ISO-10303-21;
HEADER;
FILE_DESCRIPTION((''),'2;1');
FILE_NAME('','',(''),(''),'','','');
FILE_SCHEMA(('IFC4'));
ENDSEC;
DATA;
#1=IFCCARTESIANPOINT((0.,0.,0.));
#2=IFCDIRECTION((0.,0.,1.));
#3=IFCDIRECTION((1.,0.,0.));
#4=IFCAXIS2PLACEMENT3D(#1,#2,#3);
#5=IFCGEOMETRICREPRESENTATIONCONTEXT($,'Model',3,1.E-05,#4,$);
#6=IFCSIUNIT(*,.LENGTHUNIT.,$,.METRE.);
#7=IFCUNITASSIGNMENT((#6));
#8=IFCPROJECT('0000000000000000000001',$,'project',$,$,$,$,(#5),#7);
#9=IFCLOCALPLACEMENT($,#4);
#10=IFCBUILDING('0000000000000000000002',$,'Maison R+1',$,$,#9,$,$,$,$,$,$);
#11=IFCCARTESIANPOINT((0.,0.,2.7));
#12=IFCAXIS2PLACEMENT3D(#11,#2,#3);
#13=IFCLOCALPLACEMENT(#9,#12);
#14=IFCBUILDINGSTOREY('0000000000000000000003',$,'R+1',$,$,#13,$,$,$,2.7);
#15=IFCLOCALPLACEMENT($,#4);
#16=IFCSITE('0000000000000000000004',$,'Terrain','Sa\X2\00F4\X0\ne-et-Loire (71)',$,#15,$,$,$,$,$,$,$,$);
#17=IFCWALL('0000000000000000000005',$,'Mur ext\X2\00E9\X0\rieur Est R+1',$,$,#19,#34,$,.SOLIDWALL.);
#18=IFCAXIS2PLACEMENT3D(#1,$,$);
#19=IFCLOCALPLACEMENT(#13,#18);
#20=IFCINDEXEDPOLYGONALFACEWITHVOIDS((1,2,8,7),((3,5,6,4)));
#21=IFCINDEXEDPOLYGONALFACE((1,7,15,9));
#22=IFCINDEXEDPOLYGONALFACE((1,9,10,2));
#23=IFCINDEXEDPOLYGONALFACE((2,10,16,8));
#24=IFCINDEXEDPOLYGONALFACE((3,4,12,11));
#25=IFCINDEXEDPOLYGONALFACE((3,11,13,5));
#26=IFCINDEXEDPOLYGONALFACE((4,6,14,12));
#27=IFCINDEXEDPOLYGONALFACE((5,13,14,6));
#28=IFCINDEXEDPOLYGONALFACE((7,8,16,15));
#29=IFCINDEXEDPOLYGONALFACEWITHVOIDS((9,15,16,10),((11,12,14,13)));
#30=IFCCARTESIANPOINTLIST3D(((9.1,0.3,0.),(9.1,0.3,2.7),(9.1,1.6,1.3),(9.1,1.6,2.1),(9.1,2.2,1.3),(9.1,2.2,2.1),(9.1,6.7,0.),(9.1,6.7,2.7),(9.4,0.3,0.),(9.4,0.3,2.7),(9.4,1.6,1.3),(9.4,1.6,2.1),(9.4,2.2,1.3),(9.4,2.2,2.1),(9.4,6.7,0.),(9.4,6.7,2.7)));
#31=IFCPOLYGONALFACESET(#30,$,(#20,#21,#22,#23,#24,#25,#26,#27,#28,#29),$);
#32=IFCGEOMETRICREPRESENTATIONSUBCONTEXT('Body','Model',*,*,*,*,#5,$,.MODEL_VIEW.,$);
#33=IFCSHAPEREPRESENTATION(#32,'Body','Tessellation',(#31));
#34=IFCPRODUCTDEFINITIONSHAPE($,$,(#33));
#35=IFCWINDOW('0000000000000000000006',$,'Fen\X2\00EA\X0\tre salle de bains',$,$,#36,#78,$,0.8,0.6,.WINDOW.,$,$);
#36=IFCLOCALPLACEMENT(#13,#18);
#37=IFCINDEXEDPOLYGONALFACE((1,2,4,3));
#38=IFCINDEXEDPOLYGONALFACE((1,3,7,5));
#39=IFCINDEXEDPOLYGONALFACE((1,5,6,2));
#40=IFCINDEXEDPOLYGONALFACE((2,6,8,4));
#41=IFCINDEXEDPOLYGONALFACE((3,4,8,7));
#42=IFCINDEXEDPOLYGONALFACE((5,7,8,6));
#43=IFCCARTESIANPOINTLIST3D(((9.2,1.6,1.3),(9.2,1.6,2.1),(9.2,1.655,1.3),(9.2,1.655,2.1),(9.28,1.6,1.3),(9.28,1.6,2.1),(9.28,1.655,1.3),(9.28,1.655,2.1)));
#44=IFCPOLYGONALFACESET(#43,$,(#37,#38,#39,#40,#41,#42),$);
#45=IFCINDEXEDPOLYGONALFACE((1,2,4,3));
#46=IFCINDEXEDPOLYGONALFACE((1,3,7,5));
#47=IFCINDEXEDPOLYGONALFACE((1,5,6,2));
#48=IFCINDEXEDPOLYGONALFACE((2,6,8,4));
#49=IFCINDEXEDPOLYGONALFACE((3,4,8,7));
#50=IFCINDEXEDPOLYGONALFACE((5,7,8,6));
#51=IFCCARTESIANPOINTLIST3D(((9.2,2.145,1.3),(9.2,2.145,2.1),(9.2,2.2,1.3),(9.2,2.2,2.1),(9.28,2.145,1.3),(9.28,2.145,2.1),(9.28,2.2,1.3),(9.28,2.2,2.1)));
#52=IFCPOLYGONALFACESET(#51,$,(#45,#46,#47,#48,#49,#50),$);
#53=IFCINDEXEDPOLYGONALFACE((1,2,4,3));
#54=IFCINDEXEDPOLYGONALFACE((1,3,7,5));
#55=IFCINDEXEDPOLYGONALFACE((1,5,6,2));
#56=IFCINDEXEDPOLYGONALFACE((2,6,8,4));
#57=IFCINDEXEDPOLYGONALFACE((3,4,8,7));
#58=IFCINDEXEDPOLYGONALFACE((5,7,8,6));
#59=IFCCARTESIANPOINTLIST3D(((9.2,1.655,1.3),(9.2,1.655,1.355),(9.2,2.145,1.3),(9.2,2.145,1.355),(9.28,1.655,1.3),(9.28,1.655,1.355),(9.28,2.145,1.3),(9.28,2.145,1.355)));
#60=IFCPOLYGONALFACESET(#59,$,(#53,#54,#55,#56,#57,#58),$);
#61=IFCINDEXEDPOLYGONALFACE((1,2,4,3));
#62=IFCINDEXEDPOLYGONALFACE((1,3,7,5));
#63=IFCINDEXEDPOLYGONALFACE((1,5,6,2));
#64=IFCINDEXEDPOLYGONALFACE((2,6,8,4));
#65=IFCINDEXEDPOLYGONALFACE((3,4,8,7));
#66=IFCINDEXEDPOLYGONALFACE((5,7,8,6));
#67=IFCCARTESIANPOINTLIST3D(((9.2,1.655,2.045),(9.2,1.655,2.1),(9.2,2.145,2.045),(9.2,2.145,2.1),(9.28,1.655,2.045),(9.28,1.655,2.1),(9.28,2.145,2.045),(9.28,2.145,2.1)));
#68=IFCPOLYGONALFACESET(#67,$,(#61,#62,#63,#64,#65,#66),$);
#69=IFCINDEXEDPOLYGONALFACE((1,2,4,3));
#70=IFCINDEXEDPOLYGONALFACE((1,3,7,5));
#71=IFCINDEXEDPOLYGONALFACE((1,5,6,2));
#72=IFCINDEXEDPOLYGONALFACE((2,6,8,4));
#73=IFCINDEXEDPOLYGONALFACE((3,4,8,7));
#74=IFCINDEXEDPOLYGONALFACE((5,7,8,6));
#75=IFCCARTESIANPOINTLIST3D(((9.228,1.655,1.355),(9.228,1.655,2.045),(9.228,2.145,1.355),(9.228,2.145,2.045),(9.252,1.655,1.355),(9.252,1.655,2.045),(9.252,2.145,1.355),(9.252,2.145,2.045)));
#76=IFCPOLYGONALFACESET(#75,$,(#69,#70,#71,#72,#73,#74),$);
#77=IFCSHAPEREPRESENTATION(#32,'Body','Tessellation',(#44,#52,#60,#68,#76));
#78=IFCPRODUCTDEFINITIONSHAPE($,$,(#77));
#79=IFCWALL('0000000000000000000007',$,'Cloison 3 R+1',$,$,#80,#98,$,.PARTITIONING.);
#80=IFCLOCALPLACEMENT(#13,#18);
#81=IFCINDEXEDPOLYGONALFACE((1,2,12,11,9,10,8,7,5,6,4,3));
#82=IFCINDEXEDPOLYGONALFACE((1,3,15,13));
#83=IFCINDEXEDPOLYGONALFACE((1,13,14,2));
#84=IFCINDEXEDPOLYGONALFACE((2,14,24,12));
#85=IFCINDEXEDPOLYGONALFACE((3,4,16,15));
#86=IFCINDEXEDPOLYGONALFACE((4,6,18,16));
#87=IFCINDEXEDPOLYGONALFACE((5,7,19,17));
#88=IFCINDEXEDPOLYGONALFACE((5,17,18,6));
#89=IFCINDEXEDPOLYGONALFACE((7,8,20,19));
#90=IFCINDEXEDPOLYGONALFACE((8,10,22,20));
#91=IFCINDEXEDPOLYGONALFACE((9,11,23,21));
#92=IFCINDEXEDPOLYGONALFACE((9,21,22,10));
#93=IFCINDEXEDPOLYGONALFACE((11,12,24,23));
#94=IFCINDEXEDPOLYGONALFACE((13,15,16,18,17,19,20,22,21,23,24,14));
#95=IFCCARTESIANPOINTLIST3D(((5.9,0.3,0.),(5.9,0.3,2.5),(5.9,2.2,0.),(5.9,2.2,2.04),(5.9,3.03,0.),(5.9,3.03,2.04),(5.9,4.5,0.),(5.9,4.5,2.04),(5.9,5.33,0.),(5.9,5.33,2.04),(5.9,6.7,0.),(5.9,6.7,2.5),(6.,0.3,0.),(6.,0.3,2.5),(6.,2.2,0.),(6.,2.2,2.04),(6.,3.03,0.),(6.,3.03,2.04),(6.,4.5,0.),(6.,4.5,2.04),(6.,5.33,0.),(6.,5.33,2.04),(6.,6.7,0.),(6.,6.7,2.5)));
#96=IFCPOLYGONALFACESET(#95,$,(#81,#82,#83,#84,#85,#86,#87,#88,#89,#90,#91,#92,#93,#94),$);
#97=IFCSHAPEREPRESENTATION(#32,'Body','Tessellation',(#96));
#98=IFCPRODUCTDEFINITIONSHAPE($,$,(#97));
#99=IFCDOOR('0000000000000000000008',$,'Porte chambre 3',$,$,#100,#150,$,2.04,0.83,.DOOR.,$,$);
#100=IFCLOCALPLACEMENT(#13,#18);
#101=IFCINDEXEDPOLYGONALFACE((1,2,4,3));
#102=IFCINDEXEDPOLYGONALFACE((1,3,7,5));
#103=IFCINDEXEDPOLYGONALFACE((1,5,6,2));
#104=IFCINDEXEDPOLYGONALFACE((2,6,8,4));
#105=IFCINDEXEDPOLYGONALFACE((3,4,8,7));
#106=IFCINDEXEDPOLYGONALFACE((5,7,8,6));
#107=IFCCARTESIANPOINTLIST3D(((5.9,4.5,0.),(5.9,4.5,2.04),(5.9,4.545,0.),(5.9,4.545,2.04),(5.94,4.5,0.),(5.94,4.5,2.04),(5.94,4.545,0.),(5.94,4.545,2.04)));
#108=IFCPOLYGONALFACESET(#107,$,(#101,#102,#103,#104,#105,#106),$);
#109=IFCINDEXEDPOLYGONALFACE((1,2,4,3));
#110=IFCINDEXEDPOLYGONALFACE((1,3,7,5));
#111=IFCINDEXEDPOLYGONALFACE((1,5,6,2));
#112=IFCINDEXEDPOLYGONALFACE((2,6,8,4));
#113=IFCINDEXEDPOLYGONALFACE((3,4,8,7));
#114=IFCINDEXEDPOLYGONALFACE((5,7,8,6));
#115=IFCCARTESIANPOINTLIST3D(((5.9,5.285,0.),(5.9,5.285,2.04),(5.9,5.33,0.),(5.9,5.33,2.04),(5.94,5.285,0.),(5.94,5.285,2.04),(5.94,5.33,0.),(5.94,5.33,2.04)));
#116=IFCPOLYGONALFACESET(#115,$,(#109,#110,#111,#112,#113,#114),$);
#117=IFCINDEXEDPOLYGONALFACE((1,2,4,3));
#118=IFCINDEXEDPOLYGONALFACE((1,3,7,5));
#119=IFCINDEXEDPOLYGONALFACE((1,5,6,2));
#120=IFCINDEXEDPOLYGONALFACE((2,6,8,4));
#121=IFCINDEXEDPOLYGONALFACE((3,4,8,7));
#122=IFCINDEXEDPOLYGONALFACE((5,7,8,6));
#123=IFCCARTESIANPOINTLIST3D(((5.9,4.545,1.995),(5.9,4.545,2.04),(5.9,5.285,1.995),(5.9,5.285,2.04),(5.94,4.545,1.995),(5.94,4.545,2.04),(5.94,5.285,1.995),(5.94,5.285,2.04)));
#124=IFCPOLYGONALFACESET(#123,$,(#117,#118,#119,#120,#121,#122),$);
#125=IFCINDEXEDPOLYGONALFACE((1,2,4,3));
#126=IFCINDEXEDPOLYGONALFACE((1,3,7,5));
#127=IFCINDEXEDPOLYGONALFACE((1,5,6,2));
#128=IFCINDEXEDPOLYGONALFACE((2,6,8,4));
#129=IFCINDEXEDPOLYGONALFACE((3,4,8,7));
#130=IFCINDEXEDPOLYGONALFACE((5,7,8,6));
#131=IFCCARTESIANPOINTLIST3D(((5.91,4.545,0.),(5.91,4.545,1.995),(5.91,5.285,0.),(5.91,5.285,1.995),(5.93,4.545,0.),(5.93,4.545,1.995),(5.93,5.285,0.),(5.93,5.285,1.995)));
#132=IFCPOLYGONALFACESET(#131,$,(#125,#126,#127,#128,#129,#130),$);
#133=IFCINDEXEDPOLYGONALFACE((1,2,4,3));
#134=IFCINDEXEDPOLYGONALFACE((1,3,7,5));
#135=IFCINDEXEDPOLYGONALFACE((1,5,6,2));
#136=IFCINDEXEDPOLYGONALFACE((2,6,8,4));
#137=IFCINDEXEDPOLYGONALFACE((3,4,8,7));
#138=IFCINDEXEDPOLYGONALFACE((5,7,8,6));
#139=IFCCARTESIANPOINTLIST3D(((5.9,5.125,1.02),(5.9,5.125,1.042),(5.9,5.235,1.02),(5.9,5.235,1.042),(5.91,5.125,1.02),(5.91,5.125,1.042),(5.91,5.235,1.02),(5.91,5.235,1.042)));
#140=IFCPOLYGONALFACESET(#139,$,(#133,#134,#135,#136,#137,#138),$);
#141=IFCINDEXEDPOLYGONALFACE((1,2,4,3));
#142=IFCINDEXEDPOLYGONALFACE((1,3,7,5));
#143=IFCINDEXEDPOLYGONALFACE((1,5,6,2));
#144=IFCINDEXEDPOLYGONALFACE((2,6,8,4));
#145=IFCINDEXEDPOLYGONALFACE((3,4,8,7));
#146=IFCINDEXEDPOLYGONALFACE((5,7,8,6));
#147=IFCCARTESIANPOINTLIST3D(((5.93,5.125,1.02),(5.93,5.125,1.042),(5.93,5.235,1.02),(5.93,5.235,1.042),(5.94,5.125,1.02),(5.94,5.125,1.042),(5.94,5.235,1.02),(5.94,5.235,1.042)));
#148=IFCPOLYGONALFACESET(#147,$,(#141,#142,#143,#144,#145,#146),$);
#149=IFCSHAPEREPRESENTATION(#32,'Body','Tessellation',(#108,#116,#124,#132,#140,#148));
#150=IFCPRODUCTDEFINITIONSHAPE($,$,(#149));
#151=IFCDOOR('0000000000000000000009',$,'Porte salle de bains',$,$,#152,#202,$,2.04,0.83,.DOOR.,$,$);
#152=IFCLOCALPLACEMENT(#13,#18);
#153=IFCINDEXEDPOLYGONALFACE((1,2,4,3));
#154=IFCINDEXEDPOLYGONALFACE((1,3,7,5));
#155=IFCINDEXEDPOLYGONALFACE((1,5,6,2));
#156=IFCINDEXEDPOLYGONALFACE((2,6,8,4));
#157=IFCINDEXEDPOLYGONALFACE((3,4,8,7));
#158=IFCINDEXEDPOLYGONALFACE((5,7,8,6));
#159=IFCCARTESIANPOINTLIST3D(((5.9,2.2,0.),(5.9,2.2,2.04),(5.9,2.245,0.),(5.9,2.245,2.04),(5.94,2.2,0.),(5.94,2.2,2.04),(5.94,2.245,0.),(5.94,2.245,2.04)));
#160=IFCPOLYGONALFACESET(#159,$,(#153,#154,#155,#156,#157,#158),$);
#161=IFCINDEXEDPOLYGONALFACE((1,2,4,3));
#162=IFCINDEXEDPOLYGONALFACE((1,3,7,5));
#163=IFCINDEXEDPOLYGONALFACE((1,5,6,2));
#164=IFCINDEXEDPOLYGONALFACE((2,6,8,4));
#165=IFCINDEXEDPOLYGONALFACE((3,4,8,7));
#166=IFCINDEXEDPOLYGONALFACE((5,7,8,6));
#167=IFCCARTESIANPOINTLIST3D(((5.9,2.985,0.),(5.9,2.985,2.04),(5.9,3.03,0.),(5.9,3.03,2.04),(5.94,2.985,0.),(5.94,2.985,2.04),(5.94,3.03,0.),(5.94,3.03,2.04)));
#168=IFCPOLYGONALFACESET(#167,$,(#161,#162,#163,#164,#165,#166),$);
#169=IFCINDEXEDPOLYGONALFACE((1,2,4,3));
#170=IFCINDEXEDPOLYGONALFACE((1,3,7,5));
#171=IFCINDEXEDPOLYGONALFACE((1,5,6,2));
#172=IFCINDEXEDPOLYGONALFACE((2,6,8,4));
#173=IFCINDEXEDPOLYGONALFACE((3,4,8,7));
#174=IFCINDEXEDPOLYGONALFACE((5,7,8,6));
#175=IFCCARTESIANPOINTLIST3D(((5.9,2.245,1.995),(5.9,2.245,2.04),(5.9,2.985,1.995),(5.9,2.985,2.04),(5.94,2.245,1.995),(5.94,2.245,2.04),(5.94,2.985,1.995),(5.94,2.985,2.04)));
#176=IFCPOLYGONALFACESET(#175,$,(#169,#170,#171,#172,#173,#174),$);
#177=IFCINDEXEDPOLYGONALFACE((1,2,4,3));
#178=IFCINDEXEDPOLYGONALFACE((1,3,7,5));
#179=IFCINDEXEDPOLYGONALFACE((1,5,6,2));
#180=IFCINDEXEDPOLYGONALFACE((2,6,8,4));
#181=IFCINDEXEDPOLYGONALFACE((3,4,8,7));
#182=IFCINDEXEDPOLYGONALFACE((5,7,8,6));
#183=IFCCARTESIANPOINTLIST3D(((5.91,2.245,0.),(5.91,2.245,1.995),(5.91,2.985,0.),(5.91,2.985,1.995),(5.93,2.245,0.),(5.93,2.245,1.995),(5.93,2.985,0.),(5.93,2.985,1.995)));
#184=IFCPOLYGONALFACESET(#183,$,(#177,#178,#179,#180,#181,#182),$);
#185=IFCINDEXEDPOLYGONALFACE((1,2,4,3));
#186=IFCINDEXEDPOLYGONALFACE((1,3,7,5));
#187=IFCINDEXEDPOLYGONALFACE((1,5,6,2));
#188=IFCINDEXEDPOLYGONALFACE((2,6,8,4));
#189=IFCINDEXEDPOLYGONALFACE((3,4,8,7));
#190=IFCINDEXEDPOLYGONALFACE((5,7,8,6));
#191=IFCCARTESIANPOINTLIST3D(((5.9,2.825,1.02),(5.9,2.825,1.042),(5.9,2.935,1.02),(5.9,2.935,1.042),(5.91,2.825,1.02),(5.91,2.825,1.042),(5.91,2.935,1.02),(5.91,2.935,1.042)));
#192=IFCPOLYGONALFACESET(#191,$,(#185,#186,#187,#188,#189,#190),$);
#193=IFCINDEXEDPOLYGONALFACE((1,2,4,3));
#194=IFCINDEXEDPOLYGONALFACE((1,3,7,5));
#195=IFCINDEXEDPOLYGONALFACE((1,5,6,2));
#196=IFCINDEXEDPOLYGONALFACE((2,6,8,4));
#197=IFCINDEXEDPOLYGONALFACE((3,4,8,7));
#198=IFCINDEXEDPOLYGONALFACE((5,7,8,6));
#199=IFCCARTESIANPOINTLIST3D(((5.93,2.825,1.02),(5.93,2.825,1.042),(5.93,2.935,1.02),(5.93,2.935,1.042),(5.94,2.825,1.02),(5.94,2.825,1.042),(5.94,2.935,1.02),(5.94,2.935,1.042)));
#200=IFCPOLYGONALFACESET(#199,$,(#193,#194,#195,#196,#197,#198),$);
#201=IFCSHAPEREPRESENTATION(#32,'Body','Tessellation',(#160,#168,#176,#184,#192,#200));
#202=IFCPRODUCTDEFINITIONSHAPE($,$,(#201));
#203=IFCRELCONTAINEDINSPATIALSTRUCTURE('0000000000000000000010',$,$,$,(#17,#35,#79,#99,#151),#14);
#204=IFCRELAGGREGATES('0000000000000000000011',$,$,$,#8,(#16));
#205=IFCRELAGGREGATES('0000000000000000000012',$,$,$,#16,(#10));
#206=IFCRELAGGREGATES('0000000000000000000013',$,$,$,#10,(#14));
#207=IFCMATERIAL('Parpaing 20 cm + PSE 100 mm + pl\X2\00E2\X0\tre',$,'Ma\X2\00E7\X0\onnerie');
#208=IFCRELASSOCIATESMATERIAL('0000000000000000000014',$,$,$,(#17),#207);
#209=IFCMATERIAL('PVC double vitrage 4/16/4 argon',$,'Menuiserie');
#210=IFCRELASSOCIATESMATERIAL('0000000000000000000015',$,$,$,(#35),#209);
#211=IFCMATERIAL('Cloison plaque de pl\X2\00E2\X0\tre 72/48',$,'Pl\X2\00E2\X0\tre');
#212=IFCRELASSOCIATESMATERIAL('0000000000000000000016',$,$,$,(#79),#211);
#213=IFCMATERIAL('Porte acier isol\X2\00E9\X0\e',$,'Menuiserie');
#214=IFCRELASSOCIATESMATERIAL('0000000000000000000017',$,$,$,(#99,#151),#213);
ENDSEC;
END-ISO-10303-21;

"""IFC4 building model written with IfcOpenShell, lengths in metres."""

from ifc_helpers import new_model, si_unit, frame, frame_2d, origin_with_axes, place, context, subcontext, project, spatial, rectangle, extrude, material, element, fill, save


model = new_model("IFC4")

# Units and contexts
model_context = context("Model", 3, precision=1e-05, world=origin_with_axes())
body_context = subcontext(model_context, "Body", "Model", "MODEL_VIEW")
ifc_project = project(units=[si_unit("LENGTHUNIT", "METRE")], contexts=[model_context])

# Site, building, storey
site_placement = place(None, origin_with_axes())
site = spatial("IfcSite", under=ifc_project, at=site_placement, Name="Terrain", Description="Saône-et-Loire (71)")
building_placement = place(None, origin_with_axes())
building = spatial("IfcBuilding", under=site, at=building_placement, Name="Maison R+1")
storey_placement = place(building_placement, frame((0.0, 0.0, 2.7), z_axis=(0.0, 0.0, 1.0), x_axis=(1.0, 0.0, 0.0)))
storey = spatial("IfcBuildingStorey", under=building, at=storey_placement, Name="R+1", Elevation=2.7)

# Wall, opening, window
ifc_material_1 = material(Name="Parpaing 20 cm + PSE 100 mm + plâtre", Category="Maçonnerie")
wall_1_placement = place(storey_placement, frame((9.1, 0.3, 0.0), z_axis=(0.0, 0.0, 1.0), x_axis=(1.0, 0.0, 0.0)))
wall_1 = element("IfcWall", 1, at=wall_1_placement, inside=storey, material=ifc_material_1, Name="Mur extérieur Est R+1", PredefinedType="SOLIDWALL", context=body_context, shape_type="SweptSolid", body=[
    extrude(rectangle(XDim=0.3, YDim=6.4, at=frame_2d((0.15, 3.2))), origin_with_axes(), (0.0, 0.0, 1.0), 2.7),
])
opening_1_placement = place(storey_placement, frame((9.05, 1.6, 1.3), z_axis=(0.0, 0.0, 1.0), x_axis=(1.0, 0.0, 0.0)))
opening_1 = element("IfcOpeningElement", 2, at=opening_1_placement, cuts=wall_1, context=body_context, shape_type="SweptSolid", body=[
    extrude(rectangle(XDim=0.4, YDim=0.6, at=frame_2d((0.2, 0.3))), origin_with_axes(), (0.0, 0.0, 1.0), 0.8),
])
ifc_material_2 = material(Name="PVC double vitrage 4/16/4 argon", Category="Menuiserie")
window_placement = place(storey_placement, frame((9.2, 1.6, 1.3), z_axis=(0.0, 0.0, 1.0), x_axis=(1.0, 0.0, 0.0)))
window = element("IfcWindow", 3, at=window_placement, inside=storey, material=ifc_material_2, Name="Fenêtre salle de bains", OverallHeight=0.8, OverallWidth=0.6, PredefinedType="WINDOW", context=body_context, shape_type="SweptSolid", body=[
    extrude(rectangle(XDim=0.08, YDim=0.055, at=frame_2d((0.04, 0.0275))), origin_with_axes(), (0.0, 0.0, 1.0), 0.8),
    extrude(rectangle(XDim=0.08, YDim=0.055, at=frame_2d((0.04, 0.0275))), frame((0.0, 0.545, 0.0), z_axis=(0.0, 0.0, 1.0), x_axis=(1.0, 0.0, 0.0)), (0.0, 0.0, 1.0), 0.8),
    extrude(rectangle(XDim=0.08, YDim=0.49, at=frame_2d((0.04, 0.245))), frame((0.0, 0.055, 0.0), z_axis=(0.0, 0.0, 1.0), x_axis=(1.0, 0.0, 0.0)), (0.0, 0.0, 1.0), 0.055),
    extrude(rectangle(XDim=0.08, YDim=0.49, at=frame_2d((0.04, 0.245))), frame((0.0, 0.055, 0.745), z_axis=(0.0, 0.0, 1.0), x_axis=(1.0, 0.0, 0.0)), (0.0, 0.0, 1.0), 0.055),
    extrude(rectangle(XDim=0.024, YDim=0.49, at=frame_2d((0.012, 0.245))), frame((0.028, 0.055, 0.055), z_axis=(0.0, 0.0, 1.0), x_axis=(1.0, 0.0, 0.0)), (0.0, 0.0, 1.0), 0.69),
])
fill(opening_1, window)

# Wall, openings, doors
ifc_material_3 = material(Name="Cloison plaque de plâtre 72/48", Category="Plâtre")
wall_2_placement = place(storey_placement, frame((5.9, 0.3, 0.0), z_axis=(0.0, 0.0, 1.0), x_axis=(1.0, 0.0, 0.0)))
wall_2 = element("IfcWall", 4, at=wall_2_placement, inside=storey, material=ifc_material_3, Name="Cloison 3 R+1", PredefinedType="PARTITIONING", context=body_context, shape_type="SweptSolid", body=[
    extrude(rectangle(XDim=0.1, YDim=6.4, at=frame_2d((0.05, 3.2))), origin_with_axes(), (0.0, 0.0, 1.0), 2.5),
])
opening_2_placement = place(storey_placement, frame((5.85, 4.5, 0.0), z_axis=(0.0, 0.0, 1.0), x_axis=(1.0, 0.0, 0.0)))
opening_2 = element("IfcOpeningElement", 5, at=opening_2_placement, cuts=wall_2, context=body_context, shape_type="SweptSolid", body=[
    extrude(rectangle(XDim=0.2, YDim=0.83, at=frame_2d((0.1, 0.415))), origin_with_axes(), (0.0, 0.0, 1.0), 2.04),
])
opening_3_placement = place(storey_placement, frame((5.85, 2.2, 0.0), z_axis=(0.0, 0.0, 1.0), x_axis=(1.0, 0.0, 0.0)))
opening_3 = element("IfcOpeningElement", 6, at=opening_3_placement, cuts=wall_2, context=body_context, shape_type="SweptSolid", body=[
    extrude(rectangle(XDim=0.2, YDim=0.83, at=frame_2d((0.1, 0.415))), origin_with_axes(), (0.0, 0.0, 1.0), 2.04),
])
ifc_material_4 = material(Name="Porte acier isolée", Category="Menuiserie")
door_1_placement = place(storey_placement, frame((5.9, 4.5, 0.0), z_axis=(0.0, 0.0, 1.0), x_axis=(1.0, 0.0, 0.0)))
door_1 = element("IfcDoor", 7, at=door_1_placement, inside=storey, material=ifc_material_4, Name="Porte chambre 3", OverallHeight=2.04, OverallWidth=0.83, PredefinedType="DOOR", context=body_context, shape_type="SweptSolid", body=[
    extrude(rectangle(XDim=0.04, YDim=0.045, at=frame_2d((0.02, 0.0225))), origin_with_axes(), (0.0, 0.0, 1.0), 2.04),
    extrude(rectangle(XDim=0.04, YDim=0.045, at=frame_2d((0.02, 0.0225))), frame((0.0, 0.785, 0.0), z_axis=(0.0, 0.0, 1.0), x_axis=(1.0, 0.0, 0.0)), (0.0, 0.0, 1.0), 2.04),
    extrude(rectangle(XDim=0.04, YDim=0.74, at=frame_2d((0.02, 0.37))), frame((0.0, 0.045, 1.995), z_axis=(0.0, 0.0, 1.0), x_axis=(1.0, 0.0, 0.0)), (0.0, 0.0, 1.0), 0.045),
    extrude(rectangle(XDim=0.02, YDim=0.74, at=frame_2d((0.01, 0.37))), frame((0.01, 0.045, 0.0), z_axis=(0.0, 0.0, 1.0), x_axis=(1.0, 0.0, 0.0)), (0.0, 0.0, 1.0), 1.995),
    extrude(rectangle(XDim=0.01, YDim=0.11, at=frame_2d((0.005, 0.055))), frame((0.0, 0.625, 1.02), z_axis=(0.0, 0.0, 1.0), x_axis=(1.0, 0.0, 0.0)), (0.0, 0.0, 1.0), 0.022),
    extrude(rectangle(XDim=0.01, YDim=0.11, at=frame_2d((0.005, 0.055))), frame((0.03, 0.625, 1.02), z_axis=(0.0, 0.0, 1.0), x_axis=(1.0, 0.0, 0.0)), (0.0, 0.0, 1.0), 0.022),
])
fill(opening_2, door_1)
door_2_placement = place(storey_placement, frame((5.9, 2.2, 0.0), z_axis=(0.0, 0.0, 1.0), x_axis=(1.0, 0.0, 0.0)))
door_2 = element("IfcDoor", 8, at=door_2_placement, inside=storey, material=ifc_material_4, Name="Porte salle de bains", OverallHeight=2.04, OverallWidth=0.83, PredefinedType="DOOR", context=body_context, shape_type="SweptSolid", body=[
    extrude(rectangle(XDim=0.04, YDim=0.045, at=frame_2d((0.02, 0.0225))), origin_with_axes(), (0.0, 0.0, 1.0), 2.04),
    extrude(rectangle(XDim=0.04, YDim=0.045, at=frame_2d((0.02, 0.0225))), frame((0.0, 0.785, 0.0), z_axis=(0.0, 0.0, 1.0), x_axis=(1.0, 0.0, 0.0)), (0.0, 0.0, 1.0), 2.04),
    extrude(rectangle(XDim=0.04, YDim=0.74, at=frame_2d((0.02, 0.37))), frame((0.0, 0.045, 1.995), z_axis=(0.0, 0.0, 1.0), x_axis=(1.0, 0.0, 0.0)), (0.0, 0.0, 1.0), 0.045),
    extrude(rectangle(XDim=0.02, YDim=0.74, at=frame_2d((0.01, 0.37))), frame((0.01, 0.045, 0.0), z_axis=(0.0, 0.0, 1.0), x_axis=(1.0, 0.0, 0.0)), (0.0, 0.0, 1.0), 1.995),
    extrude(rectangle(XDim=0.01, YDim=0.11, at=frame_2d((0.005, 0.055))), frame((0.0, 0.625, 1.02), z_axis=(0.0, 0.0, 1.0), x_axis=(1.0, 0.0, 0.0)), (0.0, 0.0, 1.0), 0.022),
    extrude(rectangle(XDim=0.01, YDim=0.11, at=frame_2d((0.005, 0.055))), frame((0.03, 0.625, 1.02), z_axis=(0.0, 0.0, 1.0), x_axis=(1.0, 0.0, 0.0)), (0.0, 0.0, 1.0), 0.022),
])
fill(opening_3, door_2)

save(model, "model.ifc")
